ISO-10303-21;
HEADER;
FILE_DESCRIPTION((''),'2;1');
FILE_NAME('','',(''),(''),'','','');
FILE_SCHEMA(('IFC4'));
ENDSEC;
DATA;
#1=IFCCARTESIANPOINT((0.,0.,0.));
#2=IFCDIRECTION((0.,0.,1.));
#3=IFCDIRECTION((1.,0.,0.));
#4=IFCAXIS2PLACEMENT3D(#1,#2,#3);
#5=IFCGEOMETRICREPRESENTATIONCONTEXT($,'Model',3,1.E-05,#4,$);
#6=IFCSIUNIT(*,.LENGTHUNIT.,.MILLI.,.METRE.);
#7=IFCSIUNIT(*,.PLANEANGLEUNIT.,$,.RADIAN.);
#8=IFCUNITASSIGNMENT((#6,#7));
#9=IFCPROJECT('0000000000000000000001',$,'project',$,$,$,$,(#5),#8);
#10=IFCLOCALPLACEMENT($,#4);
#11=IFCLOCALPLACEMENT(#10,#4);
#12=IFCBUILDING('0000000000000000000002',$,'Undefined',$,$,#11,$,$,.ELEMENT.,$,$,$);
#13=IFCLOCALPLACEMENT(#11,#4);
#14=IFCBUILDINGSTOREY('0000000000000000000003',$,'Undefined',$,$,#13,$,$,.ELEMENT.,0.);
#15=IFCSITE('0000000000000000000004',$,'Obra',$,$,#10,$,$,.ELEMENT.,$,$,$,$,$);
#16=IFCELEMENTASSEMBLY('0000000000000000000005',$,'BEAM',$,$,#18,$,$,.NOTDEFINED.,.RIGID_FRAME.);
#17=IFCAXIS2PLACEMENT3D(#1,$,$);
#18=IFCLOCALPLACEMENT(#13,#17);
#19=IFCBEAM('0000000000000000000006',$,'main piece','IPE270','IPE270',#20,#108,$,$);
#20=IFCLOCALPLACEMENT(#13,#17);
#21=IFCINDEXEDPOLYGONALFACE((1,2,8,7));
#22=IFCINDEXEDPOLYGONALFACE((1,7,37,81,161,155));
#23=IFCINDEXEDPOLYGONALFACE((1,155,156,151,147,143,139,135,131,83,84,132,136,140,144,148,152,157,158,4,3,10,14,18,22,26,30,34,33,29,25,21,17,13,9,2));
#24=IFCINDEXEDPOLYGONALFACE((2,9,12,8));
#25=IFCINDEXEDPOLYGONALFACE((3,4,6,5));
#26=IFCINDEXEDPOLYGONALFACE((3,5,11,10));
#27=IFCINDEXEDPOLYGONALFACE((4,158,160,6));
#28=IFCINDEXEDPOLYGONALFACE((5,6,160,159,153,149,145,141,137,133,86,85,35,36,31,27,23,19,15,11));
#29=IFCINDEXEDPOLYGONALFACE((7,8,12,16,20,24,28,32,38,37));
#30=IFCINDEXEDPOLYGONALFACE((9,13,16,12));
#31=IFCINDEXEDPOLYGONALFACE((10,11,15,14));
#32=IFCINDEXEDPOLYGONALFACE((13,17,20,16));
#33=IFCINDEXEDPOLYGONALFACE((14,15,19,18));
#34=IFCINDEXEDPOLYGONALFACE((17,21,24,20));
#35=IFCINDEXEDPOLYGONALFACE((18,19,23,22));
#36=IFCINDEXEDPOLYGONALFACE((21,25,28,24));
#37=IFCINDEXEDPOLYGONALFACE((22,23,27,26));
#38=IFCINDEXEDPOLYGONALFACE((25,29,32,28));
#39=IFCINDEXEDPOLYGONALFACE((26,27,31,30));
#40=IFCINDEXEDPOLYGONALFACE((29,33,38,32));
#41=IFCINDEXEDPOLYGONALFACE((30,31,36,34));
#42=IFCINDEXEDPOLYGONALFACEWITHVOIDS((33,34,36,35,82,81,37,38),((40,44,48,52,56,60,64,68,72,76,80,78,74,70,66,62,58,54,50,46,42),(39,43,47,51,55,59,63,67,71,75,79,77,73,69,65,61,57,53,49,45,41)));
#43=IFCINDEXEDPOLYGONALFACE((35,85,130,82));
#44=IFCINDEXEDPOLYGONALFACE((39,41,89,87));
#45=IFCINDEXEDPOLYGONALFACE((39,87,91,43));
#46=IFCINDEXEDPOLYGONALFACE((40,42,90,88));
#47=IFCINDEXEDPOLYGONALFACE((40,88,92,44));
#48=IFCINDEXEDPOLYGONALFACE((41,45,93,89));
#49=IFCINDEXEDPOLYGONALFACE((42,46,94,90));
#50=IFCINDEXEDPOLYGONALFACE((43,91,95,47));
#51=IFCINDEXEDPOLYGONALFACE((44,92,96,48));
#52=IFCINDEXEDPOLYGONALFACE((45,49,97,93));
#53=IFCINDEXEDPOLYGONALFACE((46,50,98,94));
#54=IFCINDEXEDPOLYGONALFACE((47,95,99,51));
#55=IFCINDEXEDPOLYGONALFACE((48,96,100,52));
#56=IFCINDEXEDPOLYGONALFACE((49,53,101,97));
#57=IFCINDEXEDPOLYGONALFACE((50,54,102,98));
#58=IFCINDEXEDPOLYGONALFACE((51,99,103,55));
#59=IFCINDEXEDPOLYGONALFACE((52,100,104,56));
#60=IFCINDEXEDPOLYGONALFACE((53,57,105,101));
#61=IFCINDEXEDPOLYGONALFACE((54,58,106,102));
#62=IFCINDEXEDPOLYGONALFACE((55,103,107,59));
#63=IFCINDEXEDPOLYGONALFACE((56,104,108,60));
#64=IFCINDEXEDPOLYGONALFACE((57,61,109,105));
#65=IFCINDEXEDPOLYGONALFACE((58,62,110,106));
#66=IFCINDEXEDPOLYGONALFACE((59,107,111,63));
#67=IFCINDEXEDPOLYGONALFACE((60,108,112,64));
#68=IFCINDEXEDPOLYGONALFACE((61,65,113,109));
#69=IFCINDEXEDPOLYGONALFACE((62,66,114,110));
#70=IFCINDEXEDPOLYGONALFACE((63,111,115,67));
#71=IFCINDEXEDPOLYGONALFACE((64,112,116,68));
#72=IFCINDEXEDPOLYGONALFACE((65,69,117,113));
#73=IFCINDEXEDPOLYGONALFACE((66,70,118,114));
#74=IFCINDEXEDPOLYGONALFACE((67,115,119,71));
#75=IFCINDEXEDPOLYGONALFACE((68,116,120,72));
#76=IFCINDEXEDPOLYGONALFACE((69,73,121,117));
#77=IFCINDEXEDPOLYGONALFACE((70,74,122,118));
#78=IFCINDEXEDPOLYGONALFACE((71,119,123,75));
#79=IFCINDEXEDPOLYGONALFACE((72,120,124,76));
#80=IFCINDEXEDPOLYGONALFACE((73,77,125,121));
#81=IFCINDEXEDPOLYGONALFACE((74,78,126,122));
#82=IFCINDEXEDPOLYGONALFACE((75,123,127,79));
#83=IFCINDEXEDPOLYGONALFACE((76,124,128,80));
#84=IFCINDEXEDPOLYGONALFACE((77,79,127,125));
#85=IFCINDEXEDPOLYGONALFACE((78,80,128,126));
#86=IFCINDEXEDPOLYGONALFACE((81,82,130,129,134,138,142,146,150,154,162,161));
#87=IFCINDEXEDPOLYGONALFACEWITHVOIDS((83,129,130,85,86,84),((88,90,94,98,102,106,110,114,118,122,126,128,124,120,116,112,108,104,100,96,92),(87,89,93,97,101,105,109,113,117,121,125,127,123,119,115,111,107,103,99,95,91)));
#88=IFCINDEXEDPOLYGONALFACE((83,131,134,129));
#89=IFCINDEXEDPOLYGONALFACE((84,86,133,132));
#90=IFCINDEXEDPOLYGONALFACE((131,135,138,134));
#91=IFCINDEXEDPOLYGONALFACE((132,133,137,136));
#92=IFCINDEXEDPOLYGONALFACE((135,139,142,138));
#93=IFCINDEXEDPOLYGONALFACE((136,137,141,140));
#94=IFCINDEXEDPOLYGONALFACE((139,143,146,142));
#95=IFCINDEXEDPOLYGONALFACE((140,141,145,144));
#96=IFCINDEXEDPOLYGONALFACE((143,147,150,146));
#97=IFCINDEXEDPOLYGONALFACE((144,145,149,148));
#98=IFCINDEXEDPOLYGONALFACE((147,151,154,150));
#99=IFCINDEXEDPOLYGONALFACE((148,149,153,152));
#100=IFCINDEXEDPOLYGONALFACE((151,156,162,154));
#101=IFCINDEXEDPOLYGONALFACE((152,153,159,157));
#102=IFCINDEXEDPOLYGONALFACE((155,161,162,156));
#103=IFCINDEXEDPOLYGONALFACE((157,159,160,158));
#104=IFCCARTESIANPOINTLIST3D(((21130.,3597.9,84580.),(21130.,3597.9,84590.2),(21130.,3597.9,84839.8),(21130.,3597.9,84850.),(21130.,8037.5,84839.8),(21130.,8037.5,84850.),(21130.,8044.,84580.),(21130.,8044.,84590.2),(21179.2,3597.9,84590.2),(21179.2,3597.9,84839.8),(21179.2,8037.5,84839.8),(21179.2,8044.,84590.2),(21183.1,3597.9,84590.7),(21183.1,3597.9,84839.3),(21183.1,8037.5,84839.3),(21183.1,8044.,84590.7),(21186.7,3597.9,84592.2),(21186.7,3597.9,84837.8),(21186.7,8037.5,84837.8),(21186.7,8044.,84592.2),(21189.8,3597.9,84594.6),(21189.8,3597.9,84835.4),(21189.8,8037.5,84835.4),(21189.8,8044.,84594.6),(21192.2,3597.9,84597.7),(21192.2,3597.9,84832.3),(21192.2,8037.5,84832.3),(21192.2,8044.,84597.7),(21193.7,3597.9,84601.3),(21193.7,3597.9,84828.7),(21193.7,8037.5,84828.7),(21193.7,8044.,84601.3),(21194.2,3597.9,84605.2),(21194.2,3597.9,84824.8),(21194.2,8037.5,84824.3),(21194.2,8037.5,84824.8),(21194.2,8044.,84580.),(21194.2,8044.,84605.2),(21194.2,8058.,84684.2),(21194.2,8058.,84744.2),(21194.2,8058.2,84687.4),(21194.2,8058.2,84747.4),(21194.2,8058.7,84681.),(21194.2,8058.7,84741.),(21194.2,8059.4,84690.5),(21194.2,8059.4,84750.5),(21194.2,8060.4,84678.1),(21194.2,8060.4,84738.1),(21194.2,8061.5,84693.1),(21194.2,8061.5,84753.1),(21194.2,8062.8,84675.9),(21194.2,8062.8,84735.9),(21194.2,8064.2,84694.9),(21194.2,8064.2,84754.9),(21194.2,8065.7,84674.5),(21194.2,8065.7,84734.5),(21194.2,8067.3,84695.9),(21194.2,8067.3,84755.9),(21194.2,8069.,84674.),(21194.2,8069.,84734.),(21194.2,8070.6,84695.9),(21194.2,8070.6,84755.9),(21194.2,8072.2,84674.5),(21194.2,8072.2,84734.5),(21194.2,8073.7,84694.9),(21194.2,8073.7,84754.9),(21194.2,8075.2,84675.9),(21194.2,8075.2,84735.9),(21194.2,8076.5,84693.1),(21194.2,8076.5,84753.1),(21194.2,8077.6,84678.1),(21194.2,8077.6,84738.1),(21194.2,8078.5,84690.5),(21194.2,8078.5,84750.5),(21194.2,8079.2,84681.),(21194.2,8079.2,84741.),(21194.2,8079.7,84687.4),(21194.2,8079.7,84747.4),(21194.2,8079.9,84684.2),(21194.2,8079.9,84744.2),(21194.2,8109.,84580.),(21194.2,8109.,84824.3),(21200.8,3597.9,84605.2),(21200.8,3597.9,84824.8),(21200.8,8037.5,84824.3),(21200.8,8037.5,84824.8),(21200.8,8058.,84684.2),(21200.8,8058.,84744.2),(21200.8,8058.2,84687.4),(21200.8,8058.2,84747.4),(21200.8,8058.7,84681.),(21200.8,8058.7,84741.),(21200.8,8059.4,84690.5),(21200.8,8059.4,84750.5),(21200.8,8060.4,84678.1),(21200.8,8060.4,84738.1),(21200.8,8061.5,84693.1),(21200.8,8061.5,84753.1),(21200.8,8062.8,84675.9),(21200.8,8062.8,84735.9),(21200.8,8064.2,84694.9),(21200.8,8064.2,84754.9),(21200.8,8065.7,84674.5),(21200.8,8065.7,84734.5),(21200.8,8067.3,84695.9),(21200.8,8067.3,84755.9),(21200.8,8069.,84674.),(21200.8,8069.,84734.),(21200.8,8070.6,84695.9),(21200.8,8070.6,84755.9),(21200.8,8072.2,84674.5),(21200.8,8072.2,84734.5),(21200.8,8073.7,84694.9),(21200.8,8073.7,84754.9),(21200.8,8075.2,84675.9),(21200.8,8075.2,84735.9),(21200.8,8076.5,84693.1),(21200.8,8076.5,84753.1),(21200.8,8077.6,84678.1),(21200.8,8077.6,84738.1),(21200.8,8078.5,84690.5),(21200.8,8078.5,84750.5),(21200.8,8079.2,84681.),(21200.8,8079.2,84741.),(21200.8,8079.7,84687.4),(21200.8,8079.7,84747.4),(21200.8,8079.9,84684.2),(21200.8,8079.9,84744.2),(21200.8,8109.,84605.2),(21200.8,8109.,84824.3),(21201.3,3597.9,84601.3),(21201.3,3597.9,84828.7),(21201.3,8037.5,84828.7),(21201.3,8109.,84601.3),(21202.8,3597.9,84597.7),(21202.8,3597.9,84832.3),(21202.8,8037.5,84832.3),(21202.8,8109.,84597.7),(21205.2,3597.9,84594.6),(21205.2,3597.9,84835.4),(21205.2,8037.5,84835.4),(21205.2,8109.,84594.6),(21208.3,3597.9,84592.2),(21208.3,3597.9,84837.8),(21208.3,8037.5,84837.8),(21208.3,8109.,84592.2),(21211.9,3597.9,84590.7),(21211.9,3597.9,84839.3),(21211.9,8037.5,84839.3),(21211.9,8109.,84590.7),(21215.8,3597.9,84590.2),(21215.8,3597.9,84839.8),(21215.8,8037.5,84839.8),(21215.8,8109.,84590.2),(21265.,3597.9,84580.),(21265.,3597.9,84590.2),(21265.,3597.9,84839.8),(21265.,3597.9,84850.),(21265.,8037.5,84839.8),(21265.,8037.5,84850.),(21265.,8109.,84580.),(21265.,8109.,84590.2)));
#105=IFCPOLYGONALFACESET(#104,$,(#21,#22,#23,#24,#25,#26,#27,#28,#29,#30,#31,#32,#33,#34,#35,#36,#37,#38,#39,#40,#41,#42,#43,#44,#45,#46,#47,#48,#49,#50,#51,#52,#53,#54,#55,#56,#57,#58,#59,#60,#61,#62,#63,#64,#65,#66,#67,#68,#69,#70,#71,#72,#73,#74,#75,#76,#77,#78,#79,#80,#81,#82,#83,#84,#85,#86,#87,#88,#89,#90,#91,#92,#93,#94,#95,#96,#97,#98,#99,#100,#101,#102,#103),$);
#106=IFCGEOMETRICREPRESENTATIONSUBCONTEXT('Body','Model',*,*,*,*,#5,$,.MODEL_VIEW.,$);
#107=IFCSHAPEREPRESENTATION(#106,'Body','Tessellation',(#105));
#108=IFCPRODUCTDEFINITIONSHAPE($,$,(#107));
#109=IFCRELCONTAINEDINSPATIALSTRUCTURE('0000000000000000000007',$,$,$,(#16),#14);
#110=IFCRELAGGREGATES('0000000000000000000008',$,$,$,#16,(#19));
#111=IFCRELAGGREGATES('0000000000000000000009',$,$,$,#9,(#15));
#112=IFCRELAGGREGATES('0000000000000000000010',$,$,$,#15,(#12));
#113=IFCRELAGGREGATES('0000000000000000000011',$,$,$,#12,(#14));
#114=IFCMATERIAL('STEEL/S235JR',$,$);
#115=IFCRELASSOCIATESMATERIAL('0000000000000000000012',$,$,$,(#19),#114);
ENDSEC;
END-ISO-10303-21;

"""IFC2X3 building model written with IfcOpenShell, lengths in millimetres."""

from ifc_helpers import new_model, si_unit, frame, origin_with_axes, origin_2d_with_axis, place, context, subcontext, project, spatial, rectangle, circle, i_section, extrude, clip, halfspace, source, transform, mapped, material, element, aggregate, save


model = new_model("IFC2X3")

# Units and contexts
model_context = context("Model", 3, precision=1e-05, world=origin_with_axes())
body_context = subcontext(model_context, "Body", "Model", "MODEL_VIEW")
ifc_project = project(units=[si_unit("LENGTHUNIT", "METRE", prefix="MILLI"), si_unit("PLANEANGLEUNIT", "RADIAN")], contexts=[model_context])

# Site, building, storey
site_placement = place(None, origin_with_axes())
site = spatial("IfcSite", under=ifc_project, at=site_placement, Name="Obra", CompositionType="ELEMENT")
building_placement = place(site_placement, origin_with_axes())
building = spatial("IfcBuilding", under=site, at=building_placement, Name="Undefined", CompositionType="ELEMENT")
storey_placement = place(building_placement, origin_with_axes())
storey = spatial("IfcBuildingStorey", under=building, at=storey_placement, Name="Undefined", CompositionType="ELEMENT", Elevation=0.0)

# Shared definitions
ifc_material = material(Name="STEEL/S235JR")

# Element assembly, beam, openings
assembly_1_placement = place(storey_placement, origin_with_axes())
assembly_1 = element("IfcElementAssembly", 1, at=assembly_1_placement, inside=storey, Name="BEAM", AssemblyPlace="NOTDEFINED", PredefinedType="RIGID_FRAME")
beam_1_placement = place(assembly_1_placement, frame((21197.5, 3598.0, 84715.0), z_axis=(0.0, 0.0, 1.0), x_axis=(0.0, 1.0, 0.0)))
beam_1 = element("IfcBeam", 2, at=beam_1_placement, material=ifc_material, Name="main piece", Description="IPE270", ObjectType="IPE270", context=body_context, shape_type="Clipping", body=[
    clip(extrude(i_section(OverallWidth=135.0, OverallDepth=270.0, WebThickness=6.6, FlangeThickness=10.2, FilletRadius=15.0, at=origin_2d_with_axis()), frame((4511.0, 0.0, 0.0), z_axis=(-1.0, 0.0, 0.0), x_axis=(0.0, -1.0, 0.0)), (0.0, 0.0, 1.0), 4511.0), halfspace(frame((4511.0, 0.0, -235.0), z_axis=(-1.0, 0.0, 0.0), x_axis=(0.0, 1.0, 0.0)), True)),
])
opening_1_placement = place(assembly_1_placement, frame((21197.5, 3598.0, 84715.0), z_axis=(0.0, 0.0, 1.0), x_axis=(0.0, 1.0, 0.0)))
element("IfcOpeningElement", 3, at=opening_1_placement, cuts=beam_1, ObjectType="Recess", context=body_context, shape_type="SweptSolid", body=[
    extrude(rectangle(XDim=75.0, YDim=300.0, at=origin_2d_with_axis()), frame((4483.5, 153.3, 124.3), z_axis=(0.0, 0.0, -1.0), x_axis=(-1.0, 0.0, 0.0)), (0.0, 0.0, 1.0), 278.6),
])
opening_2_placement = place(assembly_1_placement, frame((21197.5, 3598.0, 84715.0), z_axis=(0.0, 0.0, 1.0), x_axis=(0.0, 1.0, 0.0)))
element("IfcOpeningElement", 4, at=opening_2_placement, cuts=beam_1, ObjectType="Recess", context=body_context, shape_type="SweptSolid", body=[
    extrude(rectangle(XDim=26.7, YDim=83.5, at=origin_2d_with_axis()), frame((4481.3, 68.5, 122.7), z_axis=(0.0, -1.0, 0.0), x_axis=(0.0, 0.0, -1.0)), (0.0, 0.0, 1.0), 137.0),
])
shared_shape_1 = source(origin_with_axes(), body_context, "Body", "SweptSolid", [
    extrude(circle(Radius=11.0, at=origin_2d_with_axis()), frame((0.0, -3.4, 0.0), z_axis=(0.0, 1.0, 0.0), x_axis=(1.0, 0.0, 0.0)), (0.0, 0.0, 1.0), 6.8),
])
opening_3_placement = place(assembly_1_placement, frame((21197.5, 8109.0, 84850.0), z_axis=(0.0, -1.0, 0.0), x_axis=(0.0, 0.0, -1.0)))
element("IfcOpeningElement", 5, at=opening_3_placement, cuts=beam_1, ObjectType="Opening", context=body_context, shape_type="MappedRepresentation", body=[
    mapped(shared_shape_1, transform((105.0, 0.0, 40.0))),
    mapped(shared_shape_1, transform((165.0, 0.0, 40.0))),
])
aggregate(assembly_1, [beam_1])

save(model, "model.ifc")
